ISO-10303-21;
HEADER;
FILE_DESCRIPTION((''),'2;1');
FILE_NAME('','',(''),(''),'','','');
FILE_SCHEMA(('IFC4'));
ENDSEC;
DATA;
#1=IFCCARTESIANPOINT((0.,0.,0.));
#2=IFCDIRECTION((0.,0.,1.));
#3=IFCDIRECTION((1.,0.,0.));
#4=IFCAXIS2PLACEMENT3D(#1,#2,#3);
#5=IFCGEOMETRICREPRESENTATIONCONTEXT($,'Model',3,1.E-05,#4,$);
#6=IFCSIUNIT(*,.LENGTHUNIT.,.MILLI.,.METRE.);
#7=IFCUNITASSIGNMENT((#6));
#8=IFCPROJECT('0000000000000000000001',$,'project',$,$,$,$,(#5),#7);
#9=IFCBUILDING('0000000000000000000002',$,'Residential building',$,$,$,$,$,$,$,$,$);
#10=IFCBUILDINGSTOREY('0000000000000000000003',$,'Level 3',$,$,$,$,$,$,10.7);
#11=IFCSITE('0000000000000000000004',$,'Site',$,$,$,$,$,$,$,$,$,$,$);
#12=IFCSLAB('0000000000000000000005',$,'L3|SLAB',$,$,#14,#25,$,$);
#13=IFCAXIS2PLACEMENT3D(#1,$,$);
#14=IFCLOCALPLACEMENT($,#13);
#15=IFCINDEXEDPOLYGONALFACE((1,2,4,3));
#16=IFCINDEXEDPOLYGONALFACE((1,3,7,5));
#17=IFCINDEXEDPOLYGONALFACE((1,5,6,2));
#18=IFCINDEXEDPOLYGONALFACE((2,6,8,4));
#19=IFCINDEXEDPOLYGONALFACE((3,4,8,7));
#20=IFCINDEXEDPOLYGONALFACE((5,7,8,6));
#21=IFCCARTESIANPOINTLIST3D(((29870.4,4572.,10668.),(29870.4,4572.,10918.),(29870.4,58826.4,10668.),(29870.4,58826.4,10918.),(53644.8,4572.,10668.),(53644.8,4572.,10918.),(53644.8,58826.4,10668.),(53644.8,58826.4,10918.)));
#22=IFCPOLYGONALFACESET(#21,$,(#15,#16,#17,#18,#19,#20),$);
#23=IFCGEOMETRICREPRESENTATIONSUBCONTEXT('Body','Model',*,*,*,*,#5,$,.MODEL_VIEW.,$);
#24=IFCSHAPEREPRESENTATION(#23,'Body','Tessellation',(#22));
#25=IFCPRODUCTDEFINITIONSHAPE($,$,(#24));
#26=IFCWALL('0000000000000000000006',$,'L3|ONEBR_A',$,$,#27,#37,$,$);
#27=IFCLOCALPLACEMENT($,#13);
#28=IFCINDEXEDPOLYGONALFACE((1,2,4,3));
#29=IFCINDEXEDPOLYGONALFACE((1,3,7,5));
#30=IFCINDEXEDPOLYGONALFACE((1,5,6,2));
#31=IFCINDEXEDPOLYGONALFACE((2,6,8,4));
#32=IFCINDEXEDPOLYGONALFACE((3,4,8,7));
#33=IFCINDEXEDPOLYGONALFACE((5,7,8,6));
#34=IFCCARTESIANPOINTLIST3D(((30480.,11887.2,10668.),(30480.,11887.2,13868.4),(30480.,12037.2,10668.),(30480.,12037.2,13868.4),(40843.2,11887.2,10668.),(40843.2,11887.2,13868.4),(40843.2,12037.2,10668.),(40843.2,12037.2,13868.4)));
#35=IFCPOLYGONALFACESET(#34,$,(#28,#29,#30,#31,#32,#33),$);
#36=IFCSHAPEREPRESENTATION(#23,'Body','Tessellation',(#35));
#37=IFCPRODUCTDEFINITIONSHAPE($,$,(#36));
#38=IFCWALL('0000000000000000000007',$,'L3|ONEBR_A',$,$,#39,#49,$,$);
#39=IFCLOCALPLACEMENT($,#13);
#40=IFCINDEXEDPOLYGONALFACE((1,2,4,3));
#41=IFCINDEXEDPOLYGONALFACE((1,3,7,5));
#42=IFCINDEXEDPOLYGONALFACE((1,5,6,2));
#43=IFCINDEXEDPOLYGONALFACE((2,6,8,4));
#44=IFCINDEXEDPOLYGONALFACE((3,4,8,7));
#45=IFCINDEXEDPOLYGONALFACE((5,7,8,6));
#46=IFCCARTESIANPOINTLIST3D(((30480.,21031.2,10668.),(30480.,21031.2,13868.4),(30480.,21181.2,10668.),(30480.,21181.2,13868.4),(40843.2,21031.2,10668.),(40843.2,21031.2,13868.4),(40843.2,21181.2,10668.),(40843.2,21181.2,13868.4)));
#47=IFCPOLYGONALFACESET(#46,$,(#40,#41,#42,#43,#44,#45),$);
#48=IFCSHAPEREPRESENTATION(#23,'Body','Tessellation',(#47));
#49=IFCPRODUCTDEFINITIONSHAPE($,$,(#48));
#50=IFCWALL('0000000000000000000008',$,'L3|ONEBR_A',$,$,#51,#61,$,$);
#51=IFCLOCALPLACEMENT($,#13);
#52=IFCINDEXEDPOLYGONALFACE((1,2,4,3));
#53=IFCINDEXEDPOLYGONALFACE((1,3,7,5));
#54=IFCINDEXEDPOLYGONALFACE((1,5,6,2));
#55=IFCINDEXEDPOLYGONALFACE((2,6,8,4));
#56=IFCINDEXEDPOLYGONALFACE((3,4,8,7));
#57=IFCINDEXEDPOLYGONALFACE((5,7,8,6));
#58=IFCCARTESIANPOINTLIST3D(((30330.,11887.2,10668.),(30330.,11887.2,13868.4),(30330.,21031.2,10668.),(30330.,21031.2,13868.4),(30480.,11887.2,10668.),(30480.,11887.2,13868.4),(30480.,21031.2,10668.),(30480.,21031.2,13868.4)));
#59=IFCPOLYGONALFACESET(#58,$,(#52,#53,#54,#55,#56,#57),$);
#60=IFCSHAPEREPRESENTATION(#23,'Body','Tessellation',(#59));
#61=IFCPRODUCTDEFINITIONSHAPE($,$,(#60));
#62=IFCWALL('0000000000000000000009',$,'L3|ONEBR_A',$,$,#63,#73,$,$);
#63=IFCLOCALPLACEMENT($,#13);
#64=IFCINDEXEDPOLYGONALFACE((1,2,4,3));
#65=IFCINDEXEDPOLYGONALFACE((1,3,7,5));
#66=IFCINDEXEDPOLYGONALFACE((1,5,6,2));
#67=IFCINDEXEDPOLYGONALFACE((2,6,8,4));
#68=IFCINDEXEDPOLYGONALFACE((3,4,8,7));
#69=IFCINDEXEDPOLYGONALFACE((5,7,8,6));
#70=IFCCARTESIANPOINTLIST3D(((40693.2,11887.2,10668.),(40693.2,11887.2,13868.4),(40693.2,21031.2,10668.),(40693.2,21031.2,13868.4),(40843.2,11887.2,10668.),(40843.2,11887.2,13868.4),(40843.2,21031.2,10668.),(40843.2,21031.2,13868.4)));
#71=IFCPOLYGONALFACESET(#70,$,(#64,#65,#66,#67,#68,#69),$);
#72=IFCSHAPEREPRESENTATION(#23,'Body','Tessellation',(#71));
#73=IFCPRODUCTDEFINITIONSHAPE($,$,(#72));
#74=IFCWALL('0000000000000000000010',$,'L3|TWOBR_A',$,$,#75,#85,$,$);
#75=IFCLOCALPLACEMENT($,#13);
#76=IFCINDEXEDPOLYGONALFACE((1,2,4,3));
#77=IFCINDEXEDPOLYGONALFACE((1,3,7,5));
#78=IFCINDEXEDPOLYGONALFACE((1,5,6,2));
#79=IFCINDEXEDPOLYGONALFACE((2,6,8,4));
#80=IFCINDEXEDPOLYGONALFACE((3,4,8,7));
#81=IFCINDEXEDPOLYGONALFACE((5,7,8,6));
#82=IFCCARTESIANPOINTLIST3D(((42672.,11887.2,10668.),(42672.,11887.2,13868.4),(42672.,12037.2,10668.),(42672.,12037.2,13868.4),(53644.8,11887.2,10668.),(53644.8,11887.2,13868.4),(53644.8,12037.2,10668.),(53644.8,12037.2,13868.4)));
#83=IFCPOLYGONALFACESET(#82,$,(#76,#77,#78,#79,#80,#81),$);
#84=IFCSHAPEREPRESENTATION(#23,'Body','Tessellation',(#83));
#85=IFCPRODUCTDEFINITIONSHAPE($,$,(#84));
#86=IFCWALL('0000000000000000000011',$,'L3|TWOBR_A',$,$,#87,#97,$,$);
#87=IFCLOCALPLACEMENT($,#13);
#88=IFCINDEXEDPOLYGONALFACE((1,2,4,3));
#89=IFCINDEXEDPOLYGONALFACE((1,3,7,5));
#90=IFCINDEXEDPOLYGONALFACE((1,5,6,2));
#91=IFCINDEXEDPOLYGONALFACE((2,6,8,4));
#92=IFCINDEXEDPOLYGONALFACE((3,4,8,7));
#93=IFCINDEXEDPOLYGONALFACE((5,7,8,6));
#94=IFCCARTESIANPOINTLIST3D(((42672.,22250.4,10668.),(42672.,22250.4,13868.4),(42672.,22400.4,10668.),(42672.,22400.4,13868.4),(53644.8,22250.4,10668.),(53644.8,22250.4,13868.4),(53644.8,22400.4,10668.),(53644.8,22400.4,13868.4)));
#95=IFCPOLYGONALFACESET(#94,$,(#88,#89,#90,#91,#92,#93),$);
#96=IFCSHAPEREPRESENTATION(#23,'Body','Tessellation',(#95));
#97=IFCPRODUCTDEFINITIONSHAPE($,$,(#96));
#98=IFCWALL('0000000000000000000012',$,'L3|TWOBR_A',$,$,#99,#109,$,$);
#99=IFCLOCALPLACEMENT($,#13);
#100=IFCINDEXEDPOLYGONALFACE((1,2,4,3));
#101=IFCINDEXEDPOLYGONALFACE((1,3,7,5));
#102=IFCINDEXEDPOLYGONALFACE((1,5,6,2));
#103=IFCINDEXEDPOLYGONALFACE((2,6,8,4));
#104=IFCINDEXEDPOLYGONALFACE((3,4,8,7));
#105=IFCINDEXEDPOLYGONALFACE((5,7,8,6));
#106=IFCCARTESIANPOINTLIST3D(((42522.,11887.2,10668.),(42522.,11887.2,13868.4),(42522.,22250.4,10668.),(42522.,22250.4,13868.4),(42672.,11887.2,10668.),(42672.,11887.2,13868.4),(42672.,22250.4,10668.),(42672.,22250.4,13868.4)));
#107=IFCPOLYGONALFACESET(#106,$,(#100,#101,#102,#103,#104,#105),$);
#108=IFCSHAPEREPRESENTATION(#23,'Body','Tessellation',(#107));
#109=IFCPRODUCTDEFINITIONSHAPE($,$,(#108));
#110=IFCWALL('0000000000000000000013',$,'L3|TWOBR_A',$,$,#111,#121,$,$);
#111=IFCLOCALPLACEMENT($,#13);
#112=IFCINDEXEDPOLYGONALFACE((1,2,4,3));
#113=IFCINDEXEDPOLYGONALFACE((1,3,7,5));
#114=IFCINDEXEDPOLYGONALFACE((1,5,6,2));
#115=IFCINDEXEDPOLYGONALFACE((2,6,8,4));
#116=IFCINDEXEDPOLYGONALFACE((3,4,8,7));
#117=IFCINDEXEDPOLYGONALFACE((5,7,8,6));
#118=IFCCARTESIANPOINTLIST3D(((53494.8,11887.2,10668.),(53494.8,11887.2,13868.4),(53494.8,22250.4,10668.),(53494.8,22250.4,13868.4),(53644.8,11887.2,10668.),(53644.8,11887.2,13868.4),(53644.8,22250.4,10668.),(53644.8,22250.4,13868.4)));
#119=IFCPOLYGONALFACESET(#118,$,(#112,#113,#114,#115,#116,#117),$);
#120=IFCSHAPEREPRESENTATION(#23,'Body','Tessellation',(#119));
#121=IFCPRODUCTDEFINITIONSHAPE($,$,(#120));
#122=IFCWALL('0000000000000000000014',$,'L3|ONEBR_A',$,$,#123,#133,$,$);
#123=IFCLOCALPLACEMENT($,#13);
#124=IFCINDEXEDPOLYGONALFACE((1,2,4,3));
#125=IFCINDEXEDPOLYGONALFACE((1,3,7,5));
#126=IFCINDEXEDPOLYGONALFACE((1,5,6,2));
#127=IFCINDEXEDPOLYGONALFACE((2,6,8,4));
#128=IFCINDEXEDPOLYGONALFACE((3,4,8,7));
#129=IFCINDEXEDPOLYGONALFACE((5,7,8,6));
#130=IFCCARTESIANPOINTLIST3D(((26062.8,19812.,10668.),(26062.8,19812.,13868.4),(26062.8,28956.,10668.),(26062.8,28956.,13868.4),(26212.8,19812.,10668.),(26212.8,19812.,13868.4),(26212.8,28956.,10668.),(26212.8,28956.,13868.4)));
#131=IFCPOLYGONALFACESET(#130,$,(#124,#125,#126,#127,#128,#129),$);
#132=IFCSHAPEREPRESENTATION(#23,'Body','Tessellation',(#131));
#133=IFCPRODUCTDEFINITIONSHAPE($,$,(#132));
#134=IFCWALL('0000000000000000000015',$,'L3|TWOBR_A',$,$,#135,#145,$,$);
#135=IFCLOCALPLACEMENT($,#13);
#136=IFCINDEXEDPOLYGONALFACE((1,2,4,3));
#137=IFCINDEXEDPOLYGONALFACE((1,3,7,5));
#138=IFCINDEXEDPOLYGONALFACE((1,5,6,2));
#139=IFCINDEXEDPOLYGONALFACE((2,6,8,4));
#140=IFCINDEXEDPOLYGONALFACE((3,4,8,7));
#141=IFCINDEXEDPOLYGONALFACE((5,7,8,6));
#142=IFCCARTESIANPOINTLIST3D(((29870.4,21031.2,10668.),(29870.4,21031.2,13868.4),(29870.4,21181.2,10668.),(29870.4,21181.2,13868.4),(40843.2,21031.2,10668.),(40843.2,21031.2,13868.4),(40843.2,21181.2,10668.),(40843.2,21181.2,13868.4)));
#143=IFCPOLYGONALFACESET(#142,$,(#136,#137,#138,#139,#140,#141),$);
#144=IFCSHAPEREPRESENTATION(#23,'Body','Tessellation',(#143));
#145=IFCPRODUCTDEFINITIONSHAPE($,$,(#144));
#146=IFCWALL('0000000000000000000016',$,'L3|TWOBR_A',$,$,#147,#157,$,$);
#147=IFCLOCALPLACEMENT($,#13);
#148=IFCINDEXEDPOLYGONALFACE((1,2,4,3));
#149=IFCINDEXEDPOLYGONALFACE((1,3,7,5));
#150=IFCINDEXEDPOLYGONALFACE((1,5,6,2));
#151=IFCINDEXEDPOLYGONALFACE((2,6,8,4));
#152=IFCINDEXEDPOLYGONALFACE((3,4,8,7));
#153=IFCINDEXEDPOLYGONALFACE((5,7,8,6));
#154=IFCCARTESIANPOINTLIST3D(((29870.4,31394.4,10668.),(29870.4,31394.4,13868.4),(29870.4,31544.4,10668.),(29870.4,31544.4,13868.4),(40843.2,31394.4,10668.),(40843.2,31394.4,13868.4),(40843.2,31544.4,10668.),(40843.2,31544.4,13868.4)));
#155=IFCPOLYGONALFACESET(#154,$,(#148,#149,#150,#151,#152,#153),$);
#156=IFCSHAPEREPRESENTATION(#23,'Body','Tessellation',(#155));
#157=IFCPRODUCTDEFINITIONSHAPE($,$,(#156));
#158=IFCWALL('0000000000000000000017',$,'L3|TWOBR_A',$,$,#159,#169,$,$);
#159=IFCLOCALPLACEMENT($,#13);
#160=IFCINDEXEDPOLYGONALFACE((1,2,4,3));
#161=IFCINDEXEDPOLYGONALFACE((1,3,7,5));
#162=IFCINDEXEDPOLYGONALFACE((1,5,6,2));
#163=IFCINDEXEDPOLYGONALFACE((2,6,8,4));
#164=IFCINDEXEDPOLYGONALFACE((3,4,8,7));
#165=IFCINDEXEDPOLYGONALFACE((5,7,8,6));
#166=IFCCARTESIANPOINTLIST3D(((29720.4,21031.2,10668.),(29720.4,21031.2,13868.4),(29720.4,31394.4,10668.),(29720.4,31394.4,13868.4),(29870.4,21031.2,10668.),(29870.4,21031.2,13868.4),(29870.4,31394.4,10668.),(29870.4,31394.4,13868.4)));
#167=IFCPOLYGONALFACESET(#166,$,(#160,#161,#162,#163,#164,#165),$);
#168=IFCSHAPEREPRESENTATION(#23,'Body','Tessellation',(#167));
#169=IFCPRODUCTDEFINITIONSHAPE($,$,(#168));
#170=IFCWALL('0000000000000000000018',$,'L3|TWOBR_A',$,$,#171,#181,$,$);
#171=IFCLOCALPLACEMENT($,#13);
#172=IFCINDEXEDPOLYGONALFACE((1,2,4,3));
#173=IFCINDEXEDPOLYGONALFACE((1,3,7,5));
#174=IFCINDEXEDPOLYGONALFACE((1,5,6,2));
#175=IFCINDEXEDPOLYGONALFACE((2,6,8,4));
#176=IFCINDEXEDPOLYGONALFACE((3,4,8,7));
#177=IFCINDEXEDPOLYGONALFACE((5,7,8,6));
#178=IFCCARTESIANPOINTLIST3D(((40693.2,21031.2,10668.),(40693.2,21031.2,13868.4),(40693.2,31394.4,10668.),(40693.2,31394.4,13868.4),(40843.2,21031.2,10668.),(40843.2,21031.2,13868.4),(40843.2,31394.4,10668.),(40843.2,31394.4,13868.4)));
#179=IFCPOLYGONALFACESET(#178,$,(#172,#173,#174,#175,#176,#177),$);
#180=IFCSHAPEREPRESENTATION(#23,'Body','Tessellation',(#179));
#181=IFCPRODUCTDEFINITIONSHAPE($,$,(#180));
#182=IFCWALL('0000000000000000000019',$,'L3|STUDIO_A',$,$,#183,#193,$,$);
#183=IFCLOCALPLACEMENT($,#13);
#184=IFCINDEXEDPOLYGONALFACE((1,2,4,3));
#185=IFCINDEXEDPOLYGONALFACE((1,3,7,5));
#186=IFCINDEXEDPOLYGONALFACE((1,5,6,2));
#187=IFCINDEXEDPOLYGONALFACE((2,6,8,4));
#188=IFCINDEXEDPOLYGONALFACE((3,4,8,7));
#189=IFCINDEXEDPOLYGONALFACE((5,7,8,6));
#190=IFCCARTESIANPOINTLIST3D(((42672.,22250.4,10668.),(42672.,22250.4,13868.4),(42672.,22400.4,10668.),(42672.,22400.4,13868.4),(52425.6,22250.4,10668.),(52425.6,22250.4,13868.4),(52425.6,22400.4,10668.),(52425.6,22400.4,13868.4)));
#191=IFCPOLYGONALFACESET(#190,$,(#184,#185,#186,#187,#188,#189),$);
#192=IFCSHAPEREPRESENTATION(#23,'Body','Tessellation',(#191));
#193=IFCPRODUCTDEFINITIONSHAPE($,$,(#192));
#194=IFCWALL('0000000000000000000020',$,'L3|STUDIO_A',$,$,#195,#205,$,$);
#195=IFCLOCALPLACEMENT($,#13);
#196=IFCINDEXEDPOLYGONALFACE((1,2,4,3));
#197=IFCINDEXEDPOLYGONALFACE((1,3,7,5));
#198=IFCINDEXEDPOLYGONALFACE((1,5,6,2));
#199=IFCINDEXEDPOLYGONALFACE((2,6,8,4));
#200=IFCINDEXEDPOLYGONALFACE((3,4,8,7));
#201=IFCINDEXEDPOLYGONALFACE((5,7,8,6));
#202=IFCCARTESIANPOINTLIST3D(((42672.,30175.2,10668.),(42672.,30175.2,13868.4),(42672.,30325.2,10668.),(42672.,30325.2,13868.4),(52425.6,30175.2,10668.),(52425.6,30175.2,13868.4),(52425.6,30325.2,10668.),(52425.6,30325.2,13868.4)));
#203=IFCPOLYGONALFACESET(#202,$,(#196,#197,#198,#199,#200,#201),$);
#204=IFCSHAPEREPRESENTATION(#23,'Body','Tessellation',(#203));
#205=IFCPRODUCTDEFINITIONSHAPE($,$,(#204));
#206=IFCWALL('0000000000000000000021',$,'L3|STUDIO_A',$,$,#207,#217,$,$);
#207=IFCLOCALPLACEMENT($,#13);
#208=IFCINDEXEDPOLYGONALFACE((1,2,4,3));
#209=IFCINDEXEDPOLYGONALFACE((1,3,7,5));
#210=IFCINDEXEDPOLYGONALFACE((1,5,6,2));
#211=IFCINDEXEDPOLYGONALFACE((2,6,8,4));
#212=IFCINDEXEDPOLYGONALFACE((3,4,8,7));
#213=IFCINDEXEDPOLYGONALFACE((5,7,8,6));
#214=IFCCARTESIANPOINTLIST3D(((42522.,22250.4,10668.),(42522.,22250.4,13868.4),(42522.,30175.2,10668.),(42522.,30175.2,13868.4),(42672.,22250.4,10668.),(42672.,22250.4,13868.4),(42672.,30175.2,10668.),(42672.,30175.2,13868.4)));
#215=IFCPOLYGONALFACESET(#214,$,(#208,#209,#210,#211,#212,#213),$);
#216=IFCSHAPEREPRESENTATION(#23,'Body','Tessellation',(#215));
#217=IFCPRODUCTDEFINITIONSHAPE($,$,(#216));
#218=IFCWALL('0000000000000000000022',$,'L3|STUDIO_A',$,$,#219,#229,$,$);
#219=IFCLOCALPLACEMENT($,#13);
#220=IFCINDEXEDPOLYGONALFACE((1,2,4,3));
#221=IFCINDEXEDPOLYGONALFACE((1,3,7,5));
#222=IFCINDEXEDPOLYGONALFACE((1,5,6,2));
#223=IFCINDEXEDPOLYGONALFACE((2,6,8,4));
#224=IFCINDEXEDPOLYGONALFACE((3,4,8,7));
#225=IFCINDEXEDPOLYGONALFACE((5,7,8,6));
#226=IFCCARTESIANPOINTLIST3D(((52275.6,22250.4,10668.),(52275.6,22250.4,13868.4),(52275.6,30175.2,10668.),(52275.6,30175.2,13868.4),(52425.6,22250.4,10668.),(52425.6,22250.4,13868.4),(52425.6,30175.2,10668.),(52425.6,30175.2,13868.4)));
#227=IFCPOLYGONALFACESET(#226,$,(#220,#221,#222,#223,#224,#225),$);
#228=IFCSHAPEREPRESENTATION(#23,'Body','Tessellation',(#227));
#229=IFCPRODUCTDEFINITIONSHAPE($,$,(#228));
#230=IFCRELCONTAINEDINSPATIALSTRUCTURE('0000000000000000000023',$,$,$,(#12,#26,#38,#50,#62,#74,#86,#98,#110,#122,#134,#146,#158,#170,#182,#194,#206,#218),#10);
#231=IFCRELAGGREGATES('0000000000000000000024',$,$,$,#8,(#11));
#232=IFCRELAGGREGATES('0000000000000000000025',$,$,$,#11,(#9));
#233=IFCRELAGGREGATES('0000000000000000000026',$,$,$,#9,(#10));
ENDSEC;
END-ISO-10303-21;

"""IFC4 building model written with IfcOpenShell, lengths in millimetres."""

from ifc_helpers import new_model, si_unit, frame, origin_with_axes, place, context, subcontext, project, spatial, indexed_curve, outline, extrude, element, save


model = new_model("IFC4")

# Units and contexts
model_context = context("Model", 3, precision=1e-05, world=origin_with_axes())
body_context = subcontext(model_context, "Body", "Model", "MODEL_VIEW")
ifc_project = project(units=[si_unit("LENGTHUNIT", "METRE", prefix="MILLI")], contexts=[model_context])

# Site, building, storey
site = spatial("IfcSite", under=ifc_project, Name="Site")
building = spatial("IfcBuilding", under=site, Name="Residential building")
storey = spatial("IfcBuildingStorey", under=building, Name="Level 3", Elevation=10.7)

# Slab
slab_placement = place(None, frame((29870.4, 4572.0, 10668.0), z_axis=(0.0, 0.0, 1.0), x_axis=(1.0, 0.0, 0.0)))
element("IfcSlab", 1, at=slab_placement, inside=storey, Name="L3|SLAB", context=body_context, shape_type="SweptSolid", body=[
    extrude(outline(indexed_curve([(0.0, 0.0), (23774.4, 0.0), (23774.4, 54254.4), (0.0, 54254.4), (0.0, 0.0)])), None, (0.0, 0.0, 1.0), 250.0),
])

# Walls
for number, where, z_axis, x_axis, name in (
    (2, (30480.0, 11887.2, 10668.0), (0.0, 0.0, 1.0), (1.0, 0.0, 0.0), "L3|ONEBR_A"),
    (3, (30480.0, 21031.2, 10668.0), (0.0, 0.0, 1.0), (1.0, 0.0, 0.0), "L3|ONEBR_A"),
):
    element("IfcWall", number, at=place(None, frame(where, z_axis=z_axis, x_axis=x_axis)), inside=storey, Name=name, context=body_context, shape_type="SweptSolid", body=[
        extrude(outline(indexed_curve([(0.0, 0.0), (0.0, 150.0), (10363.2, 150.0), (10363.2, 0.0), (0.0, 0.0)], self_intersect=False)), origin_with_axes(), (0.0, 0.0, 1.0), 3200.4),
    ])
for number, where, z_axis, x_axis, name in (
    (4, (30480.0, 11887.2, 10668.0), (0.0, 0.0, 1.0), (0.0, 1.0, 0.0), "L3|ONEBR_A"),
    (5, (40843.2, 11887.2, 10668.0), (0.0, 0.0, 1.0), (0.0, 1.0, 0.0), "L3|ONEBR_A"),
):
    element("IfcWall", number, at=place(None, frame(where, z_axis=z_axis, x_axis=x_axis)), inside=storey, Name=name, context=body_context, shape_type="SweptSolid", body=[
        extrude(outline(indexed_curve([(0.0, 0.0), (0.0, 150.0), (9144.0, 150.0), (9144.0, 0.0), (0.0, 0.0)], self_intersect=False)), origin_with_axes(), (0.0, 0.0, 1.0), 3200.4),
    ])
for number, where, z_axis, x_axis, name in (
    (6, (42672.0, 11887.2, 10668.0), (0.0, 0.0, 1.0), (1.0, 0.0, 0.0), "L3|TWOBR_A"),
    (7, (42672.0, 22250.4, 10668.0), (0.0, 0.0, 1.0), (1.0, 0.0, 0.0), "L3|TWOBR_A"),
):
    element("IfcWall", number, at=place(None, frame(where, z_axis=z_axis, x_axis=x_axis)), inside=storey, Name=name, context=body_context, shape_type="SweptSolid", body=[
        extrude(outline(indexed_curve([(0.0, 0.0), (0.0, 150.0), (10972.8, 150.0), (10972.8, 0.0), (0.0, 0.0)], self_intersect=False)), origin_with_axes(), (0.0, 0.0, 1.0), 3200.4),
    ])
for number, where, z_axis, x_axis, name in (
    (8, (42672.0, 11887.2, 10668.0), (0.0, 0.0, 1.0), (0.0, 1.0, 0.0), "L3|TWOBR_A"),
    (9, (53644.8, 11887.2, 10668.0), (0.0, 0.0, 1.0), (0.0, 1.0, 0.0), "L3|TWOBR_A"),
):
    element("IfcWall", number, at=place(None, frame(where, z_axis=z_axis, x_axis=x_axis)), inside=storey, Name=name, context=body_context, shape_type="SweptSolid", body=[
        extrude(outline(indexed_curve([(0.0, 0.0), (0.0, 150.0), (10363.2, 150.0), (10363.2, 0.0), (0.0, 0.0)], self_intersect=False)), origin_with_axes(), (0.0, 0.0, 1.0), 3200.4),
    ])
wall_placement = place(None, frame((26212.8, 19812.0, 10668.0), z_axis=(0.0, 0.0, 1.0), x_axis=(0.0, 1.0, 0.0)))
element("IfcWall", 10, at=wall_placement, inside=storey, Name="L3|ONEBR_A", context=body_context, shape_type="SweptSolid", body=[
    extrude(outline(indexed_curve([(0.0, 0.0), (0.0, 150.0), (9144.0, 150.0), (9144.0, 0.0), (0.0, 0.0)], self_intersect=False)), origin_with_axes(), (0.0, 0.0, 1.0), 3200.4),
])
for number, where, z_axis, x_axis, name in (
    (11, (29870.4, 21031.2, 10668.0), (0.0, 0.0, 1.0), (1.0, 0.0, 0.0), "L3|TWOBR_A"),
    (12, (29870.4, 31394.4, 10668.0), (0.0, 0.0, 1.0), (1.0, 0.0, 0.0), "L3|TWOBR_A"),
):
    element("IfcWall", number, at=place(None, frame(where, z_axis=z_axis, x_axis=x_axis)), inside=storey, Name=name, context=body_context, shape_type="SweptSolid", body=[
        extrude(outline(indexed_curve([(0.0, 0.0), (0.0, 150.0), (10972.8, 150.0), (10972.8, 0.0), (0.0, 0.0)], self_intersect=False)), origin_with_axes(), (0.0, 0.0, 1.0), 3200.4),
    ])
for number, where, z_axis, x_axis, name in (
    (13, (29870.4, 21031.2, 10668.0), (0.0, 0.0, 1.0), (0.0, 1.0, 0.0), "L3|TWOBR_A"),
    (14, (40843.2, 21031.2, 10668.0), (0.0, 0.0, 1.0), (0.0, 1.0, 0.0), "L3|TWOBR_A"),
):
    element("IfcWall", number, at=place(None, frame(where, z_axis=z_axis, x_axis=x_axis)), inside=storey, Name=name, context=body_context, shape_type="SweptSolid", body=[
        extrude(outline(indexed_curve([(0.0, 0.0), (0.0, 150.0), (10363.2, 150.0), (10363.2, 0.0), (0.0, 0.0)], self_intersect=False)), origin_with_axes(), (0.0, 0.0, 1.0), 3200.4),
    ])
for number, where, z_axis, x_axis, name in (
    (15, (42672.0, 22250.4, 10668.0), (0.0, 0.0, 1.0), (1.0, 0.0, 0.0), "L3|STUDIO_A"),
    (16, (42672.0, 30175.2, 10668.0), (0.0, 0.0, 1.0), (1.0, 0.0, 0.0), "L3|STUDIO_A"),
):
    element("IfcWall", number, at=place(None, frame(where, z_axis=z_axis, x_axis=x_axis)), inside=storey, Name=name, context=body_context, shape_type="SweptSolid", body=[
        extrude(outline(indexed_curve([(0.0, 0.0), (0.0, 150.0), (9753.6, 150.0), (9753.6, 0.0), (0.0, 0.0)], self_intersect=False)), origin_with_axes(), (0.0, 0.0, 1.0), 3200.4),
    ])
for number, where, z_axis, x_axis, name in (
    (17, (42672.0, 22250.4, 10668.0), (0.0, 0.0, 1.0), (0.0, 1.0, 0.0), "L3|STUDIO_A"),
    (18, (52425.6, 22250.4, 10668.0), (0.0, 0.0, 1.0), (0.0, 1.0, 0.0), "L3|STUDIO_A"),
):
    element("IfcWall", number, at=place(None, frame(where, z_axis=z_axis, x_axis=x_axis)), inside=storey, Name=name, context=body_context, shape_type="SweptSolid", body=[
        extrude(outline(indexed_curve([(0.0, 0.0), (0.0, 150.0), (7924.8, 150.0), (7924.8, 0.0), (0.0, 0.0)], self_intersect=False)), origin_with_axes(), (0.0, 0.0, 1.0), 3200.4),
    ])

save(model, "model.ifc")
